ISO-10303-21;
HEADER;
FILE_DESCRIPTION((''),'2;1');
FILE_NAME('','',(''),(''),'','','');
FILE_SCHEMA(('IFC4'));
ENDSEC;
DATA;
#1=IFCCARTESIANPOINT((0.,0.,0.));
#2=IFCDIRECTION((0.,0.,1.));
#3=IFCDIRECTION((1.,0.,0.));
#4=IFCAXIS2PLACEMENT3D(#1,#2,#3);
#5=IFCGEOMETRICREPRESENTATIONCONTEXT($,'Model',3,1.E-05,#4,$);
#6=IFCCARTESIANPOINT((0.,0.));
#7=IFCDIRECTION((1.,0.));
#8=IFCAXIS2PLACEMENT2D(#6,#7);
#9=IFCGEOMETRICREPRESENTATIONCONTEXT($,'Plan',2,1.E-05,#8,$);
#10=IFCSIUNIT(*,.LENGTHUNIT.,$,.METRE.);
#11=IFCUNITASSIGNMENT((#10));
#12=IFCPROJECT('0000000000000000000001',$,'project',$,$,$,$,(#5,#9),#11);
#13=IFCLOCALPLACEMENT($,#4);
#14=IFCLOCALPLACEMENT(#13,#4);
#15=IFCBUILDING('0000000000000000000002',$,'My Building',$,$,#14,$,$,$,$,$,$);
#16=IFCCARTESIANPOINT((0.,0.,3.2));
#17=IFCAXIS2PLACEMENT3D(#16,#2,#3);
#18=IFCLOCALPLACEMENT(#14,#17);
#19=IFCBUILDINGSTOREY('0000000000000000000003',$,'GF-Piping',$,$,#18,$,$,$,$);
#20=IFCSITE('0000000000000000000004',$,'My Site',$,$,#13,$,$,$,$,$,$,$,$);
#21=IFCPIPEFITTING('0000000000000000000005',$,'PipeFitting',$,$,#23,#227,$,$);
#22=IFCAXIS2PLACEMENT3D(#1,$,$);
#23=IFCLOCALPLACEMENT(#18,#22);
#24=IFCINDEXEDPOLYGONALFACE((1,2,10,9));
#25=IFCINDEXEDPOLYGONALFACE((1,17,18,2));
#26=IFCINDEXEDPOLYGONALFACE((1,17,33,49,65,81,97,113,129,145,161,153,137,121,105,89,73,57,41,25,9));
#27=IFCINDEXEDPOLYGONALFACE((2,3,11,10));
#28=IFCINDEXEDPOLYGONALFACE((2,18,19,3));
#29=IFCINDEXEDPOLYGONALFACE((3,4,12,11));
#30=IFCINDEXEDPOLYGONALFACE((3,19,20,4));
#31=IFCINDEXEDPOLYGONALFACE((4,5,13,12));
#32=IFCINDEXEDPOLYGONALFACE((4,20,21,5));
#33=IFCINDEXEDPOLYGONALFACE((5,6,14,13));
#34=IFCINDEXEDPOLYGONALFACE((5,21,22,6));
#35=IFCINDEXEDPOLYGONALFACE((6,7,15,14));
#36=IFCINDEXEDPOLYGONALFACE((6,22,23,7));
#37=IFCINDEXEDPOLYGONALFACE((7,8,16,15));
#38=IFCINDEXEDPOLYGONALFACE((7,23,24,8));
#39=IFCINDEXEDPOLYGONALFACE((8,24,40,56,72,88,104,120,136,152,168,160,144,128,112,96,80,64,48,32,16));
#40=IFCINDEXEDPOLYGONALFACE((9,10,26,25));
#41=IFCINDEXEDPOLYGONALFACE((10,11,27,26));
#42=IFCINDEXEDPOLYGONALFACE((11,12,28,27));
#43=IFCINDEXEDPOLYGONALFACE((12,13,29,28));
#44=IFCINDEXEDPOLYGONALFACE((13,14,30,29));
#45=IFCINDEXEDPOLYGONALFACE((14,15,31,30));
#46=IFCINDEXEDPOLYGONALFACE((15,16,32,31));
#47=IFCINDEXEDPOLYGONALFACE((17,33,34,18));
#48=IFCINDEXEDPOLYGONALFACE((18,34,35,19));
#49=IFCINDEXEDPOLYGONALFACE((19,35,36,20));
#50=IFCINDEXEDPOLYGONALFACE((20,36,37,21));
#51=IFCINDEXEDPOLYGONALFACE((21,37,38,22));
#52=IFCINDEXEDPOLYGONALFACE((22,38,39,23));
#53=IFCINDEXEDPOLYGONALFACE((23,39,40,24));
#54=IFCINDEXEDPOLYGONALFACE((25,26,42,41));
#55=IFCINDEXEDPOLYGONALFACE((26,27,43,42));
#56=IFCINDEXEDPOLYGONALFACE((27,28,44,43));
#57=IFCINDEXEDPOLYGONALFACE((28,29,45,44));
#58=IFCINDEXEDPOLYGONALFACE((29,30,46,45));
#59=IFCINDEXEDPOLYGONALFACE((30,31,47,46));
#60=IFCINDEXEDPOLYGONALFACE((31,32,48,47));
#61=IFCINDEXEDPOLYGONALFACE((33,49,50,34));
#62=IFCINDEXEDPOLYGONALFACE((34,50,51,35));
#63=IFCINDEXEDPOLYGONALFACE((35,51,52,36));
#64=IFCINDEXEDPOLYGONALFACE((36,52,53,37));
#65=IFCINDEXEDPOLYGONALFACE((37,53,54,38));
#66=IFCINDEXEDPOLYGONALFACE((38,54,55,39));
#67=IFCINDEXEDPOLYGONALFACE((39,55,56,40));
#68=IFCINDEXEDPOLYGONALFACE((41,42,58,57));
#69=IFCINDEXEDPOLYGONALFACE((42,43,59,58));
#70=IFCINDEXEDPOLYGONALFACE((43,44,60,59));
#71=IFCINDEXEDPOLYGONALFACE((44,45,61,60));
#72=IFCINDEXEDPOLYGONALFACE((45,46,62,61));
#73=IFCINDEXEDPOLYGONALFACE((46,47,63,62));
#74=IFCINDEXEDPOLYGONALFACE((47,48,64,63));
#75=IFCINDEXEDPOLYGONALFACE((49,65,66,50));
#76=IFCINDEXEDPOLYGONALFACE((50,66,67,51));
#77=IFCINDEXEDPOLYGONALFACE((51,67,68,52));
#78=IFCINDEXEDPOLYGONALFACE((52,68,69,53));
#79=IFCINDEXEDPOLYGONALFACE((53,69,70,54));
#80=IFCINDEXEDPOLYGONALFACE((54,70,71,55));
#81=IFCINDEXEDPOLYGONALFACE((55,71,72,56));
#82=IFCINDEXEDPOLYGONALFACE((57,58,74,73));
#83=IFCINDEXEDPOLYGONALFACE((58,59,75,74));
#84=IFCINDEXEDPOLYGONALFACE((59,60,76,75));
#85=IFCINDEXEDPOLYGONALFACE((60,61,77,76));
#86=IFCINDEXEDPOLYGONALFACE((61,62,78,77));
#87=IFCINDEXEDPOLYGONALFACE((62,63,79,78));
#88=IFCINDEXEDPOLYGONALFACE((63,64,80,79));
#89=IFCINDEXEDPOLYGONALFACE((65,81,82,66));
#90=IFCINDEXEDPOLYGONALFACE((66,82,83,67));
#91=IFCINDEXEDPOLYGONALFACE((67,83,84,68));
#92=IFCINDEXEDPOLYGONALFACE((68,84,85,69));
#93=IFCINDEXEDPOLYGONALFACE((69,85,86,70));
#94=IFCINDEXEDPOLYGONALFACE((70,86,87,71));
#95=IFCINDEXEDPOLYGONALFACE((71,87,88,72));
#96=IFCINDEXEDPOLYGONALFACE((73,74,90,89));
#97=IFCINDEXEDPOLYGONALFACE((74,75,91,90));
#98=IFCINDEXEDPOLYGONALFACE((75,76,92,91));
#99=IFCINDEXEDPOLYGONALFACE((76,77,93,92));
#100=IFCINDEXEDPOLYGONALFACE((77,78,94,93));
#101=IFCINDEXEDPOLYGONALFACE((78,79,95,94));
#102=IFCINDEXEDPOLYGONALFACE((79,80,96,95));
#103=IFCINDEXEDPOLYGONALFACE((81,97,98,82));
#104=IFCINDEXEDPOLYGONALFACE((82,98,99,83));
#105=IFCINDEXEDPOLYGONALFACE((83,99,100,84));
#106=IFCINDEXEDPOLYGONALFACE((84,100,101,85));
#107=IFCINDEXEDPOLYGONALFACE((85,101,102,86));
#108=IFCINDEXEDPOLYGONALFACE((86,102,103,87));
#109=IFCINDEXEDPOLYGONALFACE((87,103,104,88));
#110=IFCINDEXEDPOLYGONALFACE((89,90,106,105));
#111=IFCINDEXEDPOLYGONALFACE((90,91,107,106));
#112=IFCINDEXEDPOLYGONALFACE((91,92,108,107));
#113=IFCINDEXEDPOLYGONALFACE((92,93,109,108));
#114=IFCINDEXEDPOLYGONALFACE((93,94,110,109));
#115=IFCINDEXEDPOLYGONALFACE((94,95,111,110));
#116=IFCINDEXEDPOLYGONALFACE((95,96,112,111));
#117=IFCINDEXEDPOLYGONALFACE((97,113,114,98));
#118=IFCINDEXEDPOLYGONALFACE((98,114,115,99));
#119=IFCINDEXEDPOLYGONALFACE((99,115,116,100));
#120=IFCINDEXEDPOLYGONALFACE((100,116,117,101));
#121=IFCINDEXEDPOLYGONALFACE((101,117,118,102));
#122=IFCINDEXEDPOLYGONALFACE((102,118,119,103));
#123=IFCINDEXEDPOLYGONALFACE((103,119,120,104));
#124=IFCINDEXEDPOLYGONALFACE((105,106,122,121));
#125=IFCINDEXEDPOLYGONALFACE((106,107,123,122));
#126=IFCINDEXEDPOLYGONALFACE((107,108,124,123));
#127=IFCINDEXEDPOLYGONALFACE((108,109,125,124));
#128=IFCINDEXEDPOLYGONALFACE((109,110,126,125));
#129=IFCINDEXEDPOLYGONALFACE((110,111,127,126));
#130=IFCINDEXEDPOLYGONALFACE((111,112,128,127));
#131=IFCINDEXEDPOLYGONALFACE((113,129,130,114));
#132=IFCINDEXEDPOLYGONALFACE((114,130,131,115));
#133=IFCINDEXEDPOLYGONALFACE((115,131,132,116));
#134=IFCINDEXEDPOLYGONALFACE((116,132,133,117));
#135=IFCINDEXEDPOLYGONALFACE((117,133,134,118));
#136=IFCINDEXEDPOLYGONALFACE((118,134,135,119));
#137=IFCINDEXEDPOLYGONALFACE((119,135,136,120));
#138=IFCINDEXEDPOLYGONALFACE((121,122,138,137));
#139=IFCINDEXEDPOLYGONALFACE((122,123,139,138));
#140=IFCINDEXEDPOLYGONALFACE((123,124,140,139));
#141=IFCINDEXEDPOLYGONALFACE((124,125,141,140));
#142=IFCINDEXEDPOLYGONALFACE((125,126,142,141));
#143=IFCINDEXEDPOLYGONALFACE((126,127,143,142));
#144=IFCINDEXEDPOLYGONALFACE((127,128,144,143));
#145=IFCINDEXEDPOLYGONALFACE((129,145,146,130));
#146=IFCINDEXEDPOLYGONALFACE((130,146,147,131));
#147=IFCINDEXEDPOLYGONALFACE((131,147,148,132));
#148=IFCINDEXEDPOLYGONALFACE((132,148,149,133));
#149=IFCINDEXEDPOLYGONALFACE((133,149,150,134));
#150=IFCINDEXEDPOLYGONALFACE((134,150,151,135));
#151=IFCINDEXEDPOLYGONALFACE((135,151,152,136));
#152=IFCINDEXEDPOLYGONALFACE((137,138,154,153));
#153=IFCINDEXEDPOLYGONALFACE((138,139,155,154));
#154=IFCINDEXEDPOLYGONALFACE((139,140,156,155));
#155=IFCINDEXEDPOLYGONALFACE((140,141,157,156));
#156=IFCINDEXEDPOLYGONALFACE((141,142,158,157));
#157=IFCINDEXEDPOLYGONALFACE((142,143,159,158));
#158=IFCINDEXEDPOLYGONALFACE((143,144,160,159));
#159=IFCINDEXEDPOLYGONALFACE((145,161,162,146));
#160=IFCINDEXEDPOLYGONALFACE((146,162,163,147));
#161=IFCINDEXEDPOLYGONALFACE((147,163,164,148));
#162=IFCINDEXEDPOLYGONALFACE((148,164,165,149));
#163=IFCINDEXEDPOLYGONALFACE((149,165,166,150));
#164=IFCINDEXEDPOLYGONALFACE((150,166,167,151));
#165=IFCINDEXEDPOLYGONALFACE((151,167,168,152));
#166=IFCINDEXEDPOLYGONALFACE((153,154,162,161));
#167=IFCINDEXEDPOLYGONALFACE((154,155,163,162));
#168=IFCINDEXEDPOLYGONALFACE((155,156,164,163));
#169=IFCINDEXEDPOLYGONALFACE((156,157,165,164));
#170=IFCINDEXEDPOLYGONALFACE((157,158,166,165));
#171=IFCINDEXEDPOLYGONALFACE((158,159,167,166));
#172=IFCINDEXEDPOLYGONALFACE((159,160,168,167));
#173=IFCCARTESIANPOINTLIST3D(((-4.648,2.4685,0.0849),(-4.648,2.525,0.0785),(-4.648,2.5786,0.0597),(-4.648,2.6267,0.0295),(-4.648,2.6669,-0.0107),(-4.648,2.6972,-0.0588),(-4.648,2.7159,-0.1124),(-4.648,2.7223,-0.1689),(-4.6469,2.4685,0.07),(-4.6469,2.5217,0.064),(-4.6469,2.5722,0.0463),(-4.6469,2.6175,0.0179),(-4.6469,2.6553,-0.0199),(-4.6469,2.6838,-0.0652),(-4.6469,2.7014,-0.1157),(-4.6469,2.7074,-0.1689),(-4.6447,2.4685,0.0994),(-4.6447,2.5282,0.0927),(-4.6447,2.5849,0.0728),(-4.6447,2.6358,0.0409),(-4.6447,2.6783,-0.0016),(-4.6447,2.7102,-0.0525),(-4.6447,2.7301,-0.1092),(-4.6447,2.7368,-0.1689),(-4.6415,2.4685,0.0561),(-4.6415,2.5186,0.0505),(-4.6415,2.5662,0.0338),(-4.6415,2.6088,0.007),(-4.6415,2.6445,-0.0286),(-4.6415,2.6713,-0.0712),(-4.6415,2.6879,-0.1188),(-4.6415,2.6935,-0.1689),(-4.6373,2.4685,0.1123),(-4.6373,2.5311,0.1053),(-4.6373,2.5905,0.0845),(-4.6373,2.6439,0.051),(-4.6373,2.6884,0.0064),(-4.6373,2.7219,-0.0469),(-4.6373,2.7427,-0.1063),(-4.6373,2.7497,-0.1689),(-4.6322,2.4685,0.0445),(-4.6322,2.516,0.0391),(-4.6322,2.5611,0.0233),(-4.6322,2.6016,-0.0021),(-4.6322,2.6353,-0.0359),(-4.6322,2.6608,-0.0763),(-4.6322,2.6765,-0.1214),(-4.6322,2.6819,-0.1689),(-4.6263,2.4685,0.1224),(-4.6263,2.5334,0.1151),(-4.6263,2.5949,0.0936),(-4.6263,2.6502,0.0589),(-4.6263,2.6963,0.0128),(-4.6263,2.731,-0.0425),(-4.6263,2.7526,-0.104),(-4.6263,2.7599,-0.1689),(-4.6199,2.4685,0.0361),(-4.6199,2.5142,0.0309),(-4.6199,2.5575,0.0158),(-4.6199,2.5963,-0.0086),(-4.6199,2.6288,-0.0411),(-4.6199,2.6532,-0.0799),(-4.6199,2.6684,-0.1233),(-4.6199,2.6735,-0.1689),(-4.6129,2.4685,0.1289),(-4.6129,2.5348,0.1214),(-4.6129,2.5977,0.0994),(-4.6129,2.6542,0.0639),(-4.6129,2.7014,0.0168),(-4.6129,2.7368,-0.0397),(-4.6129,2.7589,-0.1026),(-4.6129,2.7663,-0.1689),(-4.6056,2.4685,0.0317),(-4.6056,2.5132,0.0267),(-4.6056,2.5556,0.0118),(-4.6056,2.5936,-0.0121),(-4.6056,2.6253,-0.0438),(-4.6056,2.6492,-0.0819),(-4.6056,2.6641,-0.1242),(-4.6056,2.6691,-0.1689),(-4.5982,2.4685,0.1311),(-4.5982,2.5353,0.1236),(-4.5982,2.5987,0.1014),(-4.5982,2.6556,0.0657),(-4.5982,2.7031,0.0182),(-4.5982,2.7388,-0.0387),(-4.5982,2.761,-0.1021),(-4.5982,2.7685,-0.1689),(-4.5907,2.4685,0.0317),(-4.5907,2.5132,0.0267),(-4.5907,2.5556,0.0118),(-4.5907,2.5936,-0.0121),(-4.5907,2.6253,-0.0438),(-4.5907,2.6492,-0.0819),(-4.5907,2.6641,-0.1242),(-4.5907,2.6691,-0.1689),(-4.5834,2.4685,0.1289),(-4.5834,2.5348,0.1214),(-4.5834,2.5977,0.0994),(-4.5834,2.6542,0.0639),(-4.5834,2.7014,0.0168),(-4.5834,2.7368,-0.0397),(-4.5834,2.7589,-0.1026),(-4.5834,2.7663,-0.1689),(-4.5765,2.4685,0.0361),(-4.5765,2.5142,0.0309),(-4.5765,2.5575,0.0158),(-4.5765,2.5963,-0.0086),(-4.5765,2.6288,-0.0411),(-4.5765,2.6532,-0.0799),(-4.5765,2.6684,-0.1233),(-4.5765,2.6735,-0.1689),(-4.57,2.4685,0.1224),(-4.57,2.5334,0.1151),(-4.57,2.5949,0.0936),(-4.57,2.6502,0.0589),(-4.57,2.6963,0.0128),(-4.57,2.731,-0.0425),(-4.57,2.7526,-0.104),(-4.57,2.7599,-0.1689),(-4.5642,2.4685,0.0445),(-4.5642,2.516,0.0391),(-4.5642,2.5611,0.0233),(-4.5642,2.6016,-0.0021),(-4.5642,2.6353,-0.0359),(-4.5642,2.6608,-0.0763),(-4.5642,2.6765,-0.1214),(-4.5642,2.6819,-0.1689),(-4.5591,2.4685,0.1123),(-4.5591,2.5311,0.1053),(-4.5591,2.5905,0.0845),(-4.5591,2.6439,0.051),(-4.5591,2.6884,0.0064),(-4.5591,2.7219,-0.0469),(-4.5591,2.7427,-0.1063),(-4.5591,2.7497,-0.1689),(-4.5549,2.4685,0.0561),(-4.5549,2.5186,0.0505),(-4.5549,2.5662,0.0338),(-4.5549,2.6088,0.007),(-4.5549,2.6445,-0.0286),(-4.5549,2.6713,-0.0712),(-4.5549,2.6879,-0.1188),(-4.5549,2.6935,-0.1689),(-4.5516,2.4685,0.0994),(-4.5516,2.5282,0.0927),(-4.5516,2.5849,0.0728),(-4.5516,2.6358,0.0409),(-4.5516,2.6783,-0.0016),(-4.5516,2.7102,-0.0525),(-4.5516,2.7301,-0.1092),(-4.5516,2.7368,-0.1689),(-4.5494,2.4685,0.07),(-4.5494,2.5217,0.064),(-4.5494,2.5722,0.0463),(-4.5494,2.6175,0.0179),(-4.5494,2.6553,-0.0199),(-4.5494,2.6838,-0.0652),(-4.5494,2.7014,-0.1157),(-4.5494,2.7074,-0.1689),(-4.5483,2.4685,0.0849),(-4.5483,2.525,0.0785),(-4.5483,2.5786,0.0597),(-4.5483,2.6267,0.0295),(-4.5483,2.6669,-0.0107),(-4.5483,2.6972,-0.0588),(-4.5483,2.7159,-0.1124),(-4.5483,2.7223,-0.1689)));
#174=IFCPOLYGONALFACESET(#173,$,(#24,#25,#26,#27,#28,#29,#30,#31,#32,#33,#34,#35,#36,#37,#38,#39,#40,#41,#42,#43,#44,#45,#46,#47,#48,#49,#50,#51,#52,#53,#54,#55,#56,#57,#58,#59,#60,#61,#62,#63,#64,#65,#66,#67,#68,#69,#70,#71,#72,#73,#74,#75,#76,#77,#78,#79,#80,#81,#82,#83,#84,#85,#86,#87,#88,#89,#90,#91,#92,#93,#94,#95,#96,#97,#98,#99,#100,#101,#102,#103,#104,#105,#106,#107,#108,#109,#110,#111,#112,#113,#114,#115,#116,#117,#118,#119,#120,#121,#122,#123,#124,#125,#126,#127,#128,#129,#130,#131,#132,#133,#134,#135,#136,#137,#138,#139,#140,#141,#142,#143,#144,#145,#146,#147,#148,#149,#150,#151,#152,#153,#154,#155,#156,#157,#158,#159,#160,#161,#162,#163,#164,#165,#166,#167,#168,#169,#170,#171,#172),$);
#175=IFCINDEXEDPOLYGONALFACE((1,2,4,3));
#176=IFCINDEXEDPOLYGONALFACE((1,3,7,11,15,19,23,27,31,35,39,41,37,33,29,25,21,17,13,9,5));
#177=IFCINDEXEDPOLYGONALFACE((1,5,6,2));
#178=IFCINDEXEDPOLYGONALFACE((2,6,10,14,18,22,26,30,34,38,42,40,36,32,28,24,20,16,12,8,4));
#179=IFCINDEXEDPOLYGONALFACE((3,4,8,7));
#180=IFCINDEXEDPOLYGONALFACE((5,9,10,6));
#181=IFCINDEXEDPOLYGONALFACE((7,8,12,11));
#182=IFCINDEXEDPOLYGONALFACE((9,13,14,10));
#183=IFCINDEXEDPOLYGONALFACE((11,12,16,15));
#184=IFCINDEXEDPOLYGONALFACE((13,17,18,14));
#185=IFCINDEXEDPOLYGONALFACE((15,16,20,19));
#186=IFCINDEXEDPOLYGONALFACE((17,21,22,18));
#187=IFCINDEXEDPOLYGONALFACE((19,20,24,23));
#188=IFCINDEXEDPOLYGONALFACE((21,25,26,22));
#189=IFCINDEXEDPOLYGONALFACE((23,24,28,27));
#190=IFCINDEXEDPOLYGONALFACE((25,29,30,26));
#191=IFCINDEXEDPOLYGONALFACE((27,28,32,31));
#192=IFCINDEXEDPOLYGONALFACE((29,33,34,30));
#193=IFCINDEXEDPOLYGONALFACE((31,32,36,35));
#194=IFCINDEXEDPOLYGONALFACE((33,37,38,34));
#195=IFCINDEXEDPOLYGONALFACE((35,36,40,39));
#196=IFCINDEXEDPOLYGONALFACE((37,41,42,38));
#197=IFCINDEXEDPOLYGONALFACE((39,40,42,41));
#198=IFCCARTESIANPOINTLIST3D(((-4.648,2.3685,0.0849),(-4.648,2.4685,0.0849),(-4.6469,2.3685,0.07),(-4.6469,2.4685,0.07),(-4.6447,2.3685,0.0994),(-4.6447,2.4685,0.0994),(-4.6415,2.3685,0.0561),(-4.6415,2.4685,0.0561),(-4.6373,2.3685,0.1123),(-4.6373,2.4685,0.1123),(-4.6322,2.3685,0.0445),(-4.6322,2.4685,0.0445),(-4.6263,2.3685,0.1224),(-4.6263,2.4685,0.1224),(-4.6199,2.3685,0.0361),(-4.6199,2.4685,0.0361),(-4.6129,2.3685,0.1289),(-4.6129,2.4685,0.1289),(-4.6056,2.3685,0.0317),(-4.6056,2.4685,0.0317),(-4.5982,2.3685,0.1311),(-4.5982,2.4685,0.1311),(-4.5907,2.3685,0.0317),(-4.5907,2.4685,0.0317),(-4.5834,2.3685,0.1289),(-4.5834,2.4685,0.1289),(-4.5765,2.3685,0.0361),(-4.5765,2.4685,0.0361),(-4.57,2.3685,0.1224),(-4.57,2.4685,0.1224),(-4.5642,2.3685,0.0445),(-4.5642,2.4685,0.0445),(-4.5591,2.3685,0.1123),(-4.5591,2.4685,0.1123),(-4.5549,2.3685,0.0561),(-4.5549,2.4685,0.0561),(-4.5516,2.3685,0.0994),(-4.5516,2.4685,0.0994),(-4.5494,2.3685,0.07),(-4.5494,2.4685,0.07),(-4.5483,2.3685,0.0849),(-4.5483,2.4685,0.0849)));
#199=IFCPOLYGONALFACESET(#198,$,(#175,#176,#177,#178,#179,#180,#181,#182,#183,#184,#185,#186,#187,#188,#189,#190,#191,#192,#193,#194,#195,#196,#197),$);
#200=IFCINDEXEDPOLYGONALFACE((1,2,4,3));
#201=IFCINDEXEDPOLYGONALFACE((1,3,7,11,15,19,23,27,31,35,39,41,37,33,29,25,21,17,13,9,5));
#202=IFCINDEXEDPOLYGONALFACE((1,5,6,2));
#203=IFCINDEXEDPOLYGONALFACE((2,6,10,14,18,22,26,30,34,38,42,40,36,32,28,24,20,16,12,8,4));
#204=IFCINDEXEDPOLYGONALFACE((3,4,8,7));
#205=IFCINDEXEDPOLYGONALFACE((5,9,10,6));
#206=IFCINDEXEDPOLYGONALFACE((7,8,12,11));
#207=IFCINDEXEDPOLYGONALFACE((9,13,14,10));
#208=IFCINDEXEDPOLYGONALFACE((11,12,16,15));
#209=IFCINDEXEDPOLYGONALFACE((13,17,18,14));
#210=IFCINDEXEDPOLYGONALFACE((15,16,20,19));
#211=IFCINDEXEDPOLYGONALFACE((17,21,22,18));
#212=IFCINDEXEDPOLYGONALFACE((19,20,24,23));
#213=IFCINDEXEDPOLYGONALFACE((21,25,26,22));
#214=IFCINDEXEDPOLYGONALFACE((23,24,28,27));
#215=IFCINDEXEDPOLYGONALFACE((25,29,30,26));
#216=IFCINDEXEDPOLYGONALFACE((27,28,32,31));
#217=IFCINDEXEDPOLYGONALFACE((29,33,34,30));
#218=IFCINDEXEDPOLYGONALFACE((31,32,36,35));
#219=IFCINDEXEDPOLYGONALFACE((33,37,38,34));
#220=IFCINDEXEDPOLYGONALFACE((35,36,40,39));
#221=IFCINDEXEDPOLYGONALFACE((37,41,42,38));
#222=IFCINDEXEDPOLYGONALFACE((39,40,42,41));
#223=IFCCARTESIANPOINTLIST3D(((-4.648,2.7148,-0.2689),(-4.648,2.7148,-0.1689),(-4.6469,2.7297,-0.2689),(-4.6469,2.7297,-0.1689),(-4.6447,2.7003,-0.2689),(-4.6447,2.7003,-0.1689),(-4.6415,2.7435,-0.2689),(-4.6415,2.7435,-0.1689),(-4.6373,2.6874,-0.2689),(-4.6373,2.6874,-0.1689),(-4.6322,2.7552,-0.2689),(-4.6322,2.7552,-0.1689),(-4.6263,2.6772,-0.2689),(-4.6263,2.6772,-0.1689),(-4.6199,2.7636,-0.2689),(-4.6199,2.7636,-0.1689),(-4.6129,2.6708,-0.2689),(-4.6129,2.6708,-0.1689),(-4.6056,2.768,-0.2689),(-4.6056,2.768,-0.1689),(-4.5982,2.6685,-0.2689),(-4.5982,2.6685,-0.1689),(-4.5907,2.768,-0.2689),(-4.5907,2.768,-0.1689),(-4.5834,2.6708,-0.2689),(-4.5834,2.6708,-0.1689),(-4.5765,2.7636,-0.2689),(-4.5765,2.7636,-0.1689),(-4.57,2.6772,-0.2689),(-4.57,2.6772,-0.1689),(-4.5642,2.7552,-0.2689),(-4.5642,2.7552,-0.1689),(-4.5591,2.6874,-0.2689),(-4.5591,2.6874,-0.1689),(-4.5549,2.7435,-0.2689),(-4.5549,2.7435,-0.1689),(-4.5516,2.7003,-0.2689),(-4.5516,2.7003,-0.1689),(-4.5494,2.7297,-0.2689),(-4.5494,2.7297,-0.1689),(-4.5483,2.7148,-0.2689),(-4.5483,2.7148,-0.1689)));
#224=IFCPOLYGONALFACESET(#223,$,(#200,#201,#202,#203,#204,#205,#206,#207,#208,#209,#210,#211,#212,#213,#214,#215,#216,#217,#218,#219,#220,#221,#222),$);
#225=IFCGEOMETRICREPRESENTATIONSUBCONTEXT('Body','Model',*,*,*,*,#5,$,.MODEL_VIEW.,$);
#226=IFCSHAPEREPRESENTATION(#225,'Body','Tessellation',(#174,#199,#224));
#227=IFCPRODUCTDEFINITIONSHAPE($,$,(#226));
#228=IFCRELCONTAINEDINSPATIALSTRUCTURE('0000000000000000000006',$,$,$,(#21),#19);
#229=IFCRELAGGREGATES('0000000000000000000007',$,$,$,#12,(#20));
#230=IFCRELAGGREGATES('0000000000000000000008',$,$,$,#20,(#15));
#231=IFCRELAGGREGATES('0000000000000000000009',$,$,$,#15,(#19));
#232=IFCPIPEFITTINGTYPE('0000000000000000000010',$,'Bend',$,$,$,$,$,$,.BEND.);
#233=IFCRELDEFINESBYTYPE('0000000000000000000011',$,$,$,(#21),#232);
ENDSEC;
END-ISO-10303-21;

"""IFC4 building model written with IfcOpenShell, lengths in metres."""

from ifc_helpers import new_model, entity, si_unit, frame, origin_with_axes, origin_2d_with_axis, place, context, subcontext, project, spatial, circle, extrude, source, transform, mapped, type_object, type_shapes, element, save


model = new_model("IFC4")

# Units and contexts
model_context = context("Model", 3, precision=1e-05, world=origin_with_axes())
plan_context = context("Plan", 2, precision=1e-05, world=origin_2d_with_axis())
body_context = subcontext(model_context, "Body", "Model", "MODEL_VIEW")
ifc_project = project(units=[si_unit("LENGTHUNIT", "METRE")], contexts=[model_context, plan_context])

# Site, building, storey
site_placement = place(None, origin_with_axes())
site = spatial("IfcSite", under=ifc_project, at=site_placement, Name="My Site")
building_placement = place(site_placement, origin_with_axes())
building = spatial("IfcBuilding", under=site, at=building_placement, Name="My Building")
storey_placement = place(building_placement, frame((0.0, 0.0, 3.2), z_axis=(0.0, 0.0, 1.0), x_axis=(1.0, 0.0, 0.0)))
storey = spatial("IfcBuildingStorey", under=building, at=storey_placement, Name="GF-Piping")

# Pipe fitting
pipe_fitting_type = type_object("IfcPipeFittingType", Name="Bend", PredefinedType="BEND")
shared_shape = source(origin_with_axes(), body_context, "Body", "SolidModel", [
    entity("IfcSweptDiskSolid", entity("IfcIndexedPolyCurve", entity("IfcCartesianPointList3D", [[0.0, 0.0, 0.1], [-0.0732, 0.0, 0.2768], [-0.25, 0.0, 0.35]]), [entity("IfcArcIndex", [1, 2, 3])]), 0.05),
    extrude(circle(Radius=0.05), origin_with_axes(), (0.0, 0.0, 1.0), 0.1),
    extrude(circle(Radius=0.05), frame((-0.25, 0.0, 0.35), z_axis=(-1.0, 0.0, 0.0), x_axis=(0.0, 0.0, -1.0)), (0.0, 0.0, 1.0), 0.1),
])
type_shapes(pipe_fitting_type, [shared_shape])
for number, where, z_axis, x_axis, name in (
    (1, (-4.5982, 2.3685, 0.0811), (0.0, 1.0, 0.0), (0.0, 0.0, 1.0), "PipeFitting"),
):
    element("IfcPipeFitting", number, at=place(storey_placement, frame(where, z_axis=z_axis, x_axis=x_axis)), inside=storey, type_object=pipe_fitting_type, Name=name, context=body_context, shape_type="MappedRepresentation", body=[
        mapped(shared_shape, transform((0.0, 0.0, 0.0), x_axis=(1.0, 0.0, 0.0), y_axis=(0.0, 1.0, 0.0), z_axis=(0.0, 0.0, 1.0), scale=1.0)),
    ])

save(model, "model.ifc")
